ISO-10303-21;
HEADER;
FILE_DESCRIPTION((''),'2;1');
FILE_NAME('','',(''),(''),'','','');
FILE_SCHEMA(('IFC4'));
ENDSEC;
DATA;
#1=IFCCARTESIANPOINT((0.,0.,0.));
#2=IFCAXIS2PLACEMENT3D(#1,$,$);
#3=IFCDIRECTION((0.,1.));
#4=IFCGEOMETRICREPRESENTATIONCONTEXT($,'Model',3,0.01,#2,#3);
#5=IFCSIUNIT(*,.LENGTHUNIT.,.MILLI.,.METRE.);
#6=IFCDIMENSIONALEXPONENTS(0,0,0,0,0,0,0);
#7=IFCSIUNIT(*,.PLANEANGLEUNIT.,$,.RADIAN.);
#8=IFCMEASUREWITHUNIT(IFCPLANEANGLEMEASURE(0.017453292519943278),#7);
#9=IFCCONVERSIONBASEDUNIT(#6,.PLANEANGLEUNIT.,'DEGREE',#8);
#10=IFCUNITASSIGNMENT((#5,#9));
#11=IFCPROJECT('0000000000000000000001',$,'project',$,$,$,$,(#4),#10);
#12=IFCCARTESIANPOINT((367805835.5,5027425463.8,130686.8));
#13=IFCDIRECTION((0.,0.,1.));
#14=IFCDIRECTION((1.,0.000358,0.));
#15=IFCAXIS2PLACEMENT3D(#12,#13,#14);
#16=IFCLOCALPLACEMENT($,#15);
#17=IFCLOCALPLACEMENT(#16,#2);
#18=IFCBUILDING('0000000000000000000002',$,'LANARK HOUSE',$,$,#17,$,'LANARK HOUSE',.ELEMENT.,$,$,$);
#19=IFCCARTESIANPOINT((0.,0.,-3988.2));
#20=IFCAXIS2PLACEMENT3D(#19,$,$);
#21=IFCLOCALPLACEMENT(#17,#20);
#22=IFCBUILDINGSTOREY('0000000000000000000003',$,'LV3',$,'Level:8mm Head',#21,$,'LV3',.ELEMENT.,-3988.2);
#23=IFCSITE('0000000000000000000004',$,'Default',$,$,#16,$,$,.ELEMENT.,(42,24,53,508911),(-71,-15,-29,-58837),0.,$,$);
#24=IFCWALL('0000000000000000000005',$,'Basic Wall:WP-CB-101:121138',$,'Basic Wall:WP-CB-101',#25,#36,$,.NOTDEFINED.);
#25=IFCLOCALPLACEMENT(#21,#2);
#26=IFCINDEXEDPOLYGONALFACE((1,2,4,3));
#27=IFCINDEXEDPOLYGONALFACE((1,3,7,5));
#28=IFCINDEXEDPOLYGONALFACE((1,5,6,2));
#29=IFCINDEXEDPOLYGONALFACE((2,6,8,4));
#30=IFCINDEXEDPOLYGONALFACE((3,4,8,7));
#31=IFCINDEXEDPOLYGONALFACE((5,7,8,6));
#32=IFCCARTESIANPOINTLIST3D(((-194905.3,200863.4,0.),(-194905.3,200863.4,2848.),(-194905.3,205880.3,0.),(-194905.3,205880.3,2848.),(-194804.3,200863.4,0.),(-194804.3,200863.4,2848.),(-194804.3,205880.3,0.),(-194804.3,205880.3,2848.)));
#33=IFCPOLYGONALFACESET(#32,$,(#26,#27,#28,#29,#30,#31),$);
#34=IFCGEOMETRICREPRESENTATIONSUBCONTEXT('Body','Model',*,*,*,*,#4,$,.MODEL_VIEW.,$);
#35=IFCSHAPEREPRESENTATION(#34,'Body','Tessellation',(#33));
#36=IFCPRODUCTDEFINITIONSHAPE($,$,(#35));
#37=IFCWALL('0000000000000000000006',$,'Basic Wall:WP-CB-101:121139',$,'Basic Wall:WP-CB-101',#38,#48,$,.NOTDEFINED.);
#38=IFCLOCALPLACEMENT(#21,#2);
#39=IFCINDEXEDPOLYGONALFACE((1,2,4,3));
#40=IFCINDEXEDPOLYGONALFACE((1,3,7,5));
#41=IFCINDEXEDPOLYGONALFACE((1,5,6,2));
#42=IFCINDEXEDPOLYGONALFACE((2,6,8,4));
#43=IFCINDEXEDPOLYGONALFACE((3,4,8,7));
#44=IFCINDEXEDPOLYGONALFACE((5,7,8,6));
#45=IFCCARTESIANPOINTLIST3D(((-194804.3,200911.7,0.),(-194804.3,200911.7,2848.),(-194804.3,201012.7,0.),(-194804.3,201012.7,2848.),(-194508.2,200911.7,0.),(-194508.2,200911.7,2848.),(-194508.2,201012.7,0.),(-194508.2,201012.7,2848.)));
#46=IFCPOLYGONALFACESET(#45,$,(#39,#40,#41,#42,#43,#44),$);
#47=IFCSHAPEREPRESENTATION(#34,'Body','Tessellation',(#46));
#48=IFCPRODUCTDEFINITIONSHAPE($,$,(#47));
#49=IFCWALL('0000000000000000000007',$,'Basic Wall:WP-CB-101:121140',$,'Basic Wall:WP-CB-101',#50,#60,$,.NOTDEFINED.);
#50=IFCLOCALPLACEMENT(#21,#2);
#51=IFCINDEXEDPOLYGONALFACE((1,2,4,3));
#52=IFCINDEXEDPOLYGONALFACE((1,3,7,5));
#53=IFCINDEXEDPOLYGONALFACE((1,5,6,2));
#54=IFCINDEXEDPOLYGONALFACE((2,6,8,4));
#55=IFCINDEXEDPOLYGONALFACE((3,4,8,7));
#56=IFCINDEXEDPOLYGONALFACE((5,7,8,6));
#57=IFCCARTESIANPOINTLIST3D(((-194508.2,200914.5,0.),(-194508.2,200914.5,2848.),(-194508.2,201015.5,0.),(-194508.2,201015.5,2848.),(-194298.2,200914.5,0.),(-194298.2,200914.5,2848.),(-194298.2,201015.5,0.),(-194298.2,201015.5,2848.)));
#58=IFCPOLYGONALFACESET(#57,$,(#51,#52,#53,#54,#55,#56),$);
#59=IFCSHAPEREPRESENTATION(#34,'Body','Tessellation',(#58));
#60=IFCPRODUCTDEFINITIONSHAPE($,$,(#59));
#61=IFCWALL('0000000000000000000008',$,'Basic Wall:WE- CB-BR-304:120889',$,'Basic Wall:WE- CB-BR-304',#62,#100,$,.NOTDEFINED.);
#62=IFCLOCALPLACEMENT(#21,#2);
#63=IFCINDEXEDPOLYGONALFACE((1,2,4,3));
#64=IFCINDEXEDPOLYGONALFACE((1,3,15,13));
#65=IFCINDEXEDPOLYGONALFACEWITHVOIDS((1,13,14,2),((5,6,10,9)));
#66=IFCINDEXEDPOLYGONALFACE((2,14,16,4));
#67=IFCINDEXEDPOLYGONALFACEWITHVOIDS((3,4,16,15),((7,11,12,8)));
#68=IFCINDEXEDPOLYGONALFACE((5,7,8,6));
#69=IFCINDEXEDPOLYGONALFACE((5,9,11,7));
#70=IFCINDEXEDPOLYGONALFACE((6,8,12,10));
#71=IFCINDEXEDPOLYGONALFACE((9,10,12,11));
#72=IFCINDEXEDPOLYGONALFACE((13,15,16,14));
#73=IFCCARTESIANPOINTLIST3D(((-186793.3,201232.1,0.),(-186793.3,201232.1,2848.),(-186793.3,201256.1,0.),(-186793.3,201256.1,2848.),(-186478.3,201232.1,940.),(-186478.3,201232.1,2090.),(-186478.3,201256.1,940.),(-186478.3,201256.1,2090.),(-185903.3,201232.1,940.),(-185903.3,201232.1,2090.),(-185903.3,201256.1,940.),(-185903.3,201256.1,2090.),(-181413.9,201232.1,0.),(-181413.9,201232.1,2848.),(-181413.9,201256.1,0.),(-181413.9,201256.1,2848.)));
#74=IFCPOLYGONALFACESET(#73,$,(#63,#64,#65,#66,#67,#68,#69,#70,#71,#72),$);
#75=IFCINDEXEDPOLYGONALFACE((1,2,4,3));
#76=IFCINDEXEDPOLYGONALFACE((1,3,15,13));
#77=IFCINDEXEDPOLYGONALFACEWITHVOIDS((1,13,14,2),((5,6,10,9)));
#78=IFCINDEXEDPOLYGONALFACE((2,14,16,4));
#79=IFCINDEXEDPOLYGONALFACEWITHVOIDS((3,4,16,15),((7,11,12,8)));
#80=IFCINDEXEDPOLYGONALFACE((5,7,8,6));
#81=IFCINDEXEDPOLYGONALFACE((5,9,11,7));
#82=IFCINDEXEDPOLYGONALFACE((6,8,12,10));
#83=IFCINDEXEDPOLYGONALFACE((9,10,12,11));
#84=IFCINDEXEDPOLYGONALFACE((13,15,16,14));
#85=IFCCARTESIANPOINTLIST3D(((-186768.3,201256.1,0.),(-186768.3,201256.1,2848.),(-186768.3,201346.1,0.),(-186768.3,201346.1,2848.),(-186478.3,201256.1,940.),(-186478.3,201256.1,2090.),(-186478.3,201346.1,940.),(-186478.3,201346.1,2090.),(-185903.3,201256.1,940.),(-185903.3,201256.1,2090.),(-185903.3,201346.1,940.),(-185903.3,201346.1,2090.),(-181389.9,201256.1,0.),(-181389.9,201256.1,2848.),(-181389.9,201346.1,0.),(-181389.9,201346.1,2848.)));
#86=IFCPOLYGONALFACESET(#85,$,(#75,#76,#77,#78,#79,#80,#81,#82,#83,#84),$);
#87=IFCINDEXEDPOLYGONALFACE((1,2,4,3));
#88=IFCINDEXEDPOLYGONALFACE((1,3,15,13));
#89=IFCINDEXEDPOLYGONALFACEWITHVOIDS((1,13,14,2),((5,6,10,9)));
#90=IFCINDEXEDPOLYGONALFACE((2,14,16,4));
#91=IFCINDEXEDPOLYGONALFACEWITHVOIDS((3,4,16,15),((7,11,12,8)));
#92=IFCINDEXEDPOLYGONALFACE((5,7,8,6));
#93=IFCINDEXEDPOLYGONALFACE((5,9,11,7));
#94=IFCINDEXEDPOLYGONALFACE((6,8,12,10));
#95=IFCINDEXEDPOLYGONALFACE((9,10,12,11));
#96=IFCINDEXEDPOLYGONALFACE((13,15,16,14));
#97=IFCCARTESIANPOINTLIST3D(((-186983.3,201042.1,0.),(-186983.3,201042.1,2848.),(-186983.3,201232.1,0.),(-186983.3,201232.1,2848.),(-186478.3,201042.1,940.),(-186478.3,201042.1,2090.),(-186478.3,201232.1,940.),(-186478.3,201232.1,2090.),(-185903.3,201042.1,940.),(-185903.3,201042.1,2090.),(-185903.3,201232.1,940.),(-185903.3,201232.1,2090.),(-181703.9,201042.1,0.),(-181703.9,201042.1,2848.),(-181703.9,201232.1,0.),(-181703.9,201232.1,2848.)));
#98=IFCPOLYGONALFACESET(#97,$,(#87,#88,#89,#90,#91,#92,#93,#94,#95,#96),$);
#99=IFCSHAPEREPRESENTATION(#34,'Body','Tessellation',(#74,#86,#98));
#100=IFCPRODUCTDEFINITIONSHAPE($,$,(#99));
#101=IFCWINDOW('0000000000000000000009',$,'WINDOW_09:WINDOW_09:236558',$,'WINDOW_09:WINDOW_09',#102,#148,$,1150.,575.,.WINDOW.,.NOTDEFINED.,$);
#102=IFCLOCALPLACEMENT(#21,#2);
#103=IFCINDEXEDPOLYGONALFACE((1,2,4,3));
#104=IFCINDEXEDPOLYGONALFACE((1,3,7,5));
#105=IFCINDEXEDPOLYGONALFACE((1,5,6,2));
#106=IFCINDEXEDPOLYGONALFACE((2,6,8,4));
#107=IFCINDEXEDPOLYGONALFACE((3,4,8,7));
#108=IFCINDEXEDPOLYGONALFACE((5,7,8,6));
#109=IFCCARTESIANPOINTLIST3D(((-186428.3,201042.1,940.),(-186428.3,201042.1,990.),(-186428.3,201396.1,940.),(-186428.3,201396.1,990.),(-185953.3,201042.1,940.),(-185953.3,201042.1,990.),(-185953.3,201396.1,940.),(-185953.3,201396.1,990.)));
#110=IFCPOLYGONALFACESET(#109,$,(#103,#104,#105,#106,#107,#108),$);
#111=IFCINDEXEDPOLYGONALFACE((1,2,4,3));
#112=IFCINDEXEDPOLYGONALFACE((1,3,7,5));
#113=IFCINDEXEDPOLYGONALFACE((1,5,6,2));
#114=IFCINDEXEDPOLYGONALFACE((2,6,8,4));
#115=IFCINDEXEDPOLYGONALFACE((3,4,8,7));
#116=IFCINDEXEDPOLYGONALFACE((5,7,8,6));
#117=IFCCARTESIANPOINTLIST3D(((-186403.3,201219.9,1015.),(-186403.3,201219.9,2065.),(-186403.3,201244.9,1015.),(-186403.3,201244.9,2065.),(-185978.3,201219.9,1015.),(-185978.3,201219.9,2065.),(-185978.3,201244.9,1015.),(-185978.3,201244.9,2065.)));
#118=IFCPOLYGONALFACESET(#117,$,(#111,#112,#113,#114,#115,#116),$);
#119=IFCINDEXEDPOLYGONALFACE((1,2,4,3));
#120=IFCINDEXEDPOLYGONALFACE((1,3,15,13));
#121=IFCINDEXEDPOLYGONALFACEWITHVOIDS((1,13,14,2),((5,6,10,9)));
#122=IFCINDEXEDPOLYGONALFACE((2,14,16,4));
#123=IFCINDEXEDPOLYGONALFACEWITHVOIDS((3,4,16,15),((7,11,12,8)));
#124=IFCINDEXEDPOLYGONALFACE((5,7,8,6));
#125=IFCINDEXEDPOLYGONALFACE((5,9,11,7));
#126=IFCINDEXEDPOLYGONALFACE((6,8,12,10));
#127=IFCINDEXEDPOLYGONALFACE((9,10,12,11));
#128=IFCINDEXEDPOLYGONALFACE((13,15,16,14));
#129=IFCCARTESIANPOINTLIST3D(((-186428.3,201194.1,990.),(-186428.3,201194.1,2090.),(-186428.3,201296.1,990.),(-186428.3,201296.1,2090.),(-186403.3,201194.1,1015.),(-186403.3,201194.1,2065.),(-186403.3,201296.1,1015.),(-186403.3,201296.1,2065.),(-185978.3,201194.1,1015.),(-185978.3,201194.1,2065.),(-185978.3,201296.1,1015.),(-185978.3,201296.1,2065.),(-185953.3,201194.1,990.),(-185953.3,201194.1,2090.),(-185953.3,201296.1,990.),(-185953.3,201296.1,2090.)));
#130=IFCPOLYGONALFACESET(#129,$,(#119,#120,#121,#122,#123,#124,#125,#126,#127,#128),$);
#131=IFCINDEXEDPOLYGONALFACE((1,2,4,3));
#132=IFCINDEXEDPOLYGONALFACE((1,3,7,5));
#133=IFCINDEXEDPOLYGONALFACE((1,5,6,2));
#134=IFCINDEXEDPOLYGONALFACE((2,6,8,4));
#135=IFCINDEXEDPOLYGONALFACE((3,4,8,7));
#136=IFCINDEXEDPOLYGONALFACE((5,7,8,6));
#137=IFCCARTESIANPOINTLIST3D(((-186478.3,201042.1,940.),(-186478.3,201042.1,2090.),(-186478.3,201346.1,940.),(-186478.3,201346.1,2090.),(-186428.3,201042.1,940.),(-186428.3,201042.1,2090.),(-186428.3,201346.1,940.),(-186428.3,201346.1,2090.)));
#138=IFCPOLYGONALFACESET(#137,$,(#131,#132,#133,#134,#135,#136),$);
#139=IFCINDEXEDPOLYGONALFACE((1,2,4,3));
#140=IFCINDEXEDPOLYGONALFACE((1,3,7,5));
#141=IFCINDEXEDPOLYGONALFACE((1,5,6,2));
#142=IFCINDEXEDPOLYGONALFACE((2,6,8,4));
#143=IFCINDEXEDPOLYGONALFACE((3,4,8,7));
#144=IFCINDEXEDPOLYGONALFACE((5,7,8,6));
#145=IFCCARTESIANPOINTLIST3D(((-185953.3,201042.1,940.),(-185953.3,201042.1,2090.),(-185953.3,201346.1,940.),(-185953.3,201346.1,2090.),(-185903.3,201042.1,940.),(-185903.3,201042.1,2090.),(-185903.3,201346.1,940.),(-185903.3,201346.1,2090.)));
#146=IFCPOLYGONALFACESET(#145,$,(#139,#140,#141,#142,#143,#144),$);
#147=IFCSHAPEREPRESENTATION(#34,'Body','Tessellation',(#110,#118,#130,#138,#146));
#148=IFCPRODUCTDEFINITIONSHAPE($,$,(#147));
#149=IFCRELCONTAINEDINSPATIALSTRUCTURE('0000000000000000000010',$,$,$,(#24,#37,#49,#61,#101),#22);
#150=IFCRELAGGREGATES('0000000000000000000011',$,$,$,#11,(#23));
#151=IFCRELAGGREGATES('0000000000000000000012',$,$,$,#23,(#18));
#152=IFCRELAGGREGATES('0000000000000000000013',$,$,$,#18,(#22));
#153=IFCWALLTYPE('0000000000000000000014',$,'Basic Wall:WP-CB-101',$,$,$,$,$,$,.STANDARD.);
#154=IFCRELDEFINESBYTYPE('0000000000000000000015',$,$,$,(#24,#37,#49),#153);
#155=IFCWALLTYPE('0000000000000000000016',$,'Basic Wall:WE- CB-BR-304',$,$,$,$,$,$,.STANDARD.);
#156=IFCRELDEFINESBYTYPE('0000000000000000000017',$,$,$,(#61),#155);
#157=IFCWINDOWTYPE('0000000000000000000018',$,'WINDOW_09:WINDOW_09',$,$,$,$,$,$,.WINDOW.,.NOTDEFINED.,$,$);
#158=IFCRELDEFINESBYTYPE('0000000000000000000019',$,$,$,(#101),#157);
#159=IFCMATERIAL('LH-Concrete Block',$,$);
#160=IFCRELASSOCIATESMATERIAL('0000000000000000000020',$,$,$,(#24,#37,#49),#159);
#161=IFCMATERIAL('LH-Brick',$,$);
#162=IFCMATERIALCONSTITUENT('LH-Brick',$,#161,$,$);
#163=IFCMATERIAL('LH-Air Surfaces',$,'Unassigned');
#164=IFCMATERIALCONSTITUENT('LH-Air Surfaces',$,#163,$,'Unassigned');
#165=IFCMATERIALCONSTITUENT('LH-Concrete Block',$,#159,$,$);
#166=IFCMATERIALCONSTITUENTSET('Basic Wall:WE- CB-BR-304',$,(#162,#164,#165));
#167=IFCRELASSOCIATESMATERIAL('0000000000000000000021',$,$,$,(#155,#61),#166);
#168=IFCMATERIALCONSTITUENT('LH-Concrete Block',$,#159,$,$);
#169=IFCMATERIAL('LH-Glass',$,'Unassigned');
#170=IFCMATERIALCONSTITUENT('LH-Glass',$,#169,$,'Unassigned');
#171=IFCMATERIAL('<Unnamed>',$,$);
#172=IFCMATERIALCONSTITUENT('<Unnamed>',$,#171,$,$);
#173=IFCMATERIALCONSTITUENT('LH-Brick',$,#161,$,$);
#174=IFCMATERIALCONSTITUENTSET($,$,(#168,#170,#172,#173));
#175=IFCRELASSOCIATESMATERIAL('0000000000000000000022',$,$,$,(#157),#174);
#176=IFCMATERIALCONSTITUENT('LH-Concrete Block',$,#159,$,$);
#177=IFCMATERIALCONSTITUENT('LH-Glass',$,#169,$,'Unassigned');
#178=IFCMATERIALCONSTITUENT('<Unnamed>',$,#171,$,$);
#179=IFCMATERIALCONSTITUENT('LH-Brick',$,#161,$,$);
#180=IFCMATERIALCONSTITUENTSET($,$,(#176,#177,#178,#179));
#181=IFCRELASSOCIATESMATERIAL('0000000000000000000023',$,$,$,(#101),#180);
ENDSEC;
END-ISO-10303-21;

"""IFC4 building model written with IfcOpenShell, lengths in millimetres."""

from ifc_helpers import new_model, entity, si_unit, converted_unit, direction, frame, origin, place, context, subcontext, project, spatial, indexed_curve, outline, extrude, source, transform, mapped, material, constituent, constituent_set, type_object, type_shapes, element, fill, save


model = new_model("IFC4")

# Units and contexts
model_context = context("Model", 3, precision=0.01, world=origin(), true_north=direction((0.0, 1.0)))
body_context = subcontext(model_context, "Body", "Model", "MODEL_VIEW")
ifc_project = project(units=[si_unit("LENGTHUNIT", "METRE", prefix="MILLI"), converted_unit("PLANEANGLEUNIT", "DEGREE", entity("IfcPlaneAngleMeasure", 0.017453292519943278), si_unit("PLANEANGLEUNIT", "RADIAN"), dimensions=[0, 0, 0, 0, 0, 0, 0])], contexts=[model_context])

# Site, building, storey
site_placement = place(None, frame((367805835.5, 5027425463.8, 130686.8), z_axis=(0.0, 0.0, 1.0), x_axis=(1.0, 0.000358, 0.0)))
site = spatial("IfcSite", under=ifc_project, at=site_placement, Name="Default", CompositionType="ELEMENT", RefLatitude=(42, 24, 53, 508911), RefLongitude=(-71, -15, -29, -58837), RefElevation=0.0)
building_placement = place(site_placement, origin())
building = spatial("IfcBuilding", under=site, at=building_placement, Name="LANARK HOUSE", LongName="LANARK HOUSE", CompositionType="ELEMENT")
storey_placement = place(building_placement, frame((0.0, 0.0, -3988.2)))
storey = spatial("IfcBuildingStorey", under=building, at=storey_placement, Name="LV3", ObjectType="Level:8mm Head", LongName="LV3", CompositionType="ELEMENT", Elevation=-3988.2)

# Shared definitions
ifc_material_1 = material(Name="<Unnamed>")

# Shared definitions
ifc_material_2 = material(Name="LH-Glass", Category="Unassigned")

# Walls
ifc_material_3 = material(Name="LH-Brick")
ifc_material_4 = material(Name="LH-Air Surfaces", Category="Unassigned")
ifc_material_5 = material(Name="LH-Concrete Block")
wall_type_1 = type_object("IfcWallType", Name="Basic Wall:WP-CB-101", PredefinedType="STANDARD")
wall_1_placement = place(storey_placement, frame((-194854.8, 200863.4, 0.0), z_axis=(0.0, 0.0, 1.0), x_axis=(0.0, 1.0, 0.0)))
element("IfcWall", 1, at=wall_1_placement, inside=storey, type_object=wall_type_1, material=ifc_material_5, Name="Basic Wall:WP-CB-101:121138", ObjectType="Basic Wall:WP-CB-101", PredefinedType="NOTDEFINED", context=body_context, shape_type="SweptSolid", body=[
    extrude(outline(indexed_curve([(5016.9, 50.5), (0.0, 50.5), (0.0, -50.5), (5016.9, -50.5), (5016.9, 50.5)], self_intersect=False)), origin(), (0.0, 0.0, 1.0), 2848.0),
])
wall_2_placement = place(storey_placement, frame((-194508.2, 200962.2, 0.0), z_axis=(0.0, 0.0, 1.0), x_axis=(-1.0, 0.0, 0.0)))
element("IfcWall", 2, at=wall_2_placement, inside=storey, type_object=wall_type_1, material=ifc_material_5, Name="Basic Wall:WP-CB-101:121139", ObjectType="Basic Wall:WP-CB-101", PredefinedType="NOTDEFINED", context=body_context, shape_type="SweptSolid", body=[
    extrude(outline(indexed_curve([(296.1, 50.5), (0.0, 50.5), (0.0, -50.5), (296.1, -50.5), (296.1, 50.5)], self_intersect=False)), origin(), (0.0, 0.0, 1.0), 2848.0),
])
wall_3_placement = place(storey_placement, frame((-194298.2, 200965.0, 0.0), z_axis=(0.0, 0.0, 1.0), x_axis=(-1.0, 0.0, 0.0)))
element("IfcWall", 3, at=wall_3_placement, inside=storey, type_object=wall_type_1, material=ifc_material_5, Name="Basic Wall:WP-CB-101:121140", ObjectType="Basic Wall:WP-CB-101", PredefinedType="NOTDEFINED", context=body_context, shape_type="SweptSolid", body=[
    extrude(outline(indexed_curve([(210.0, 50.5), (0.0, 50.5), (0.0, -50.5), (210.0, -50.5), (210.0, 50.5)], self_intersect=False)), origin(), (0.0, 0.0, 1.0), 2848.0),
])

# Wall, opening, window
ifc_constituent_1 = constituent(ifc_material_3, Name="LH-Brick")
ifc_constituent_2 = constituent(ifc_material_4, Name="LH-Air Surfaces", Category="Unassigned")
ifc_constituent_3 = constituent(ifc_material_5, Name="LH-Concrete Block")
ifc_constituent_set_1 = constituent_set(constituents=[ifc_constituent_1, ifc_constituent_2, ifc_constituent_3], Name="Basic Wall:WE- CB-BR-304")
wall_type_2 = type_object("IfcWallType", Name="Basic Wall:WE- CB-BR-304", PredefinedType="STANDARD", material=ifc_constituent_set_1)
wall_4_placement = place(storey_placement, frame((-187109.3, 201194.1, 0.0)))
wall_4 = element("IfcWall", 4, at=wall_4_placement, inside=storey, type_object=wall_type_2, material=ifc_constituent_set_1, Name="Basic Wall:WE- CB-BR-304:120889", ObjectType="Basic Wall:WE- CB-BR-304", PredefinedType="NOTDEFINED", context=body_context, shape_type="SweptSolid", body=[
    extrude(outline(indexed_curve([(-1424.0, -2689.7), (1424.0, -2689.7), (1424.0, 2689.7), (-1424.0, 2689.7), (-1424.0, -2689.7)], self_intersect=False), holes=[indexed_curve([(666.0, -2374.7), (-484.0, -2374.7), (-484.0, -1799.7), (666.0, -1799.7), (666.0, -2374.7)], self_intersect=False)]), frame((3005.7, 38.0, 1424.0), z_axis=(0.0, 1.0, 0.0), x_axis=(0.0, 0.0, 1.0)), (0.0, 0.0, 1.0), 24.0),
    extrude(outline(indexed_curve([(-1424.0, -2689.2), (1424.0, -2689.2), (1424.0, 2689.2), (-1424.0, 2689.2), (-1424.0, -2689.2)], self_intersect=False), holes=[indexed_curve([(666.0, -2399.2), (-484.0, -2399.2), (-484.0, -1824.2), (666.0, -1824.2), (666.0, -2399.2)], self_intersect=False)]), frame((3030.2, 62.0, 1424.0), z_axis=(0.0, 1.0, 0.0), x_axis=(0.0, 0.0, 1.0)), (0.0, 0.0, 1.0), 90.0),
    extrude(outline(indexed_curve([(-1424.0, -2639.7), (1424.0, -2639.7), (1424.0, 2639.7), (-1424.0, 2639.7), (-1424.0, -2639.7)], self_intersect=False), holes=[indexed_curve([(666.0, -2134.7), (-484.0, -2134.7), (-484.0, -1559.7), (666.0, -1559.7), (666.0, -2134.7)], self_intersect=False)]), frame((2765.7, -152.0, 1424.0), z_axis=(0.0, 1.0, 0.0), x_axis=(0.0, 0.0, 1.0)), (0.0, 0.0, 1.0), 190.0),
])
opening_1_placement = place(wall_4_placement, frame((187109.3, -201194.1, 940.0)))
opening_1 = element("IfcOpeningElement", 5, at=opening_1_placement, cuts=wall_4, PredefinedType="OPENING", context=body_context, shape_type="SweptSolid", body=[
    extrude(outline(indexed_curve([(-575.0, -287.5), (575.0, -287.5), (575.0, 287.5), (-575.0, 287.5), (-575.0, -287.5)], self_intersect=False)), frame((-186190.8, 201042.1, 575.0), z_axis=(0.0, 1.0, 0.0), x_axis=(0.0, 0.0, -1.0)), (0.0, 0.0, 1.0), 304.0),
])
ifc_constituent_4 = constituent(ifc_material_5, Name="LH-Concrete Block")
ifc_constituent_5 = constituent(ifc_material_2, Name="LH-Glass", Category="Unassigned")
ifc_constituent_6 = constituent(ifc_material_1, Name="<Unnamed>")
ifc_constituent_7 = constituent(ifc_material_3, Name="LH-Brick")
ifc_constituent_set_2 = constituent_set(constituents=[ifc_constituent_4, ifc_constituent_5, ifc_constituent_6, ifc_constituent_7])
ifc_constituent_8 = constituent(ifc_material_5, Name="LH-Concrete Block")
ifc_constituent_9 = constituent(ifc_material_2, Name="LH-Glass", Category="Unassigned")
ifc_constituent_10 = constituent(ifc_material_1, Name="<Unnamed>")
ifc_constituent_11 = constituent(ifc_material_3, Name="LH-Brick")
ifc_constituent_set_3 = constituent_set(constituents=[ifc_constituent_8, ifc_constituent_9, ifc_constituent_10, ifc_constituent_11])
window_type = type_object("IfcWindowType", Name="WINDOW_09:WINDOW_09", PartitioningType="NOTDEFINED", PredefinedType="WINDOW", material=ifc_constituent_set_3)
shared_shape_1 = source(origin(), body_context, "Body", "SweptSolid", [
    extrude(outline(indexed_curve([(-177.0, -237.5), (177.0, -237.5), (177.0, 237.5), (-177.0, 237.5), (-177.0, -237.5)], self_intersect=False)), frame((287.5, -127.0, 0.0), z_axis=(0.0, 0.0, 1.0), x_axis=(0.0, -1.0, 0.0)), (0.0, 0.0, 1.0), 50.0),
    extrude(outline(indexed_curve([(-212.5, -12.5), (212.5, -12.5), (212.5, 12.5), (-212.5, 12.5), (-212.5, -12.5)], self_intersect=False)), frame((287.5, -113.7, 75.0), z_axis=(0.0, 0.0, 1.0), x_axis=(-1.0, 0.0, 0.0)), (0.0, 0.0, 1.0), 1050.0),
    extrude(outline(indexed_curve([(-237.5, -550.0), (237.5, -550.0), (237.5, 550.0), (-237.5, 550.0), (-237.5, -550.0)], self_intersect=False), holes=[indexed_curve([(-212.5, 525.0), (212.5, 525.0), (212.5, -525.0), (-212.5, -525.0), (-212.5, 525.0)], self_intersect=False)]), frame((287.5, -152.0, 600.0), z_axis=(0.0, 1.0, 0.0), x_axis=(1.0, 0.0, 0.0)), (0.0, 0.0, 1.0), 102.0),
    extrude(outline(indexed_curve([(-25.0, -152.0), (25.0, -152.0), (25.0, 152.0), (-25.0, 152.0), (-25.0, -152.0)], self_intersect=False)), frame((25.0, -152.0, 0.0), z_axis=(0.0, 0.0, 1.0), x_axis=(-1.0, 0.0, 0.0)), (0.0, 0.0, 1.0), 1150.0),
    extrude(outline(indexed_curve([(-25.0, -152.0), (25.0, -152.0), (25.0, 152.0), (-25.0, 152.0), (-25.0, -152.0)], self_intersect=False)), frame((550.0, -152.0, 0.0), z_axis=(0.0, 0.0, 1.0), x_axis=(-1.0, 0.0, 0.0)), (0.0, 0.0, 1.0), 1150.0),
])
type_shapes(window_type, [shared_shape_1])
window_placement = place(opening_1_placement, frame((-186478.3, 201346.1, 0.0)))
window = element("IfcWindow", 6, at=window_placement, inside=storey, type_object=window_type, material=ifc_constituent_set_2, Name="WINDOW_09:WINDOW_09:236558", ObjectType="WINDOW_09:WINDOW_09", OverallHeight=1150.0, OverallWidth=575.0, PartitioningType="NOTDEFINED", PredefinedType="WINDOW", context=body_context, shape_type="MappedRepresentation", body=[
    mapped(shared_shape_1, transform((0.0, 0.0, 0.0), scale=1.0)),
])
fill(opening_1, window)

save(model, "model.ifc")
